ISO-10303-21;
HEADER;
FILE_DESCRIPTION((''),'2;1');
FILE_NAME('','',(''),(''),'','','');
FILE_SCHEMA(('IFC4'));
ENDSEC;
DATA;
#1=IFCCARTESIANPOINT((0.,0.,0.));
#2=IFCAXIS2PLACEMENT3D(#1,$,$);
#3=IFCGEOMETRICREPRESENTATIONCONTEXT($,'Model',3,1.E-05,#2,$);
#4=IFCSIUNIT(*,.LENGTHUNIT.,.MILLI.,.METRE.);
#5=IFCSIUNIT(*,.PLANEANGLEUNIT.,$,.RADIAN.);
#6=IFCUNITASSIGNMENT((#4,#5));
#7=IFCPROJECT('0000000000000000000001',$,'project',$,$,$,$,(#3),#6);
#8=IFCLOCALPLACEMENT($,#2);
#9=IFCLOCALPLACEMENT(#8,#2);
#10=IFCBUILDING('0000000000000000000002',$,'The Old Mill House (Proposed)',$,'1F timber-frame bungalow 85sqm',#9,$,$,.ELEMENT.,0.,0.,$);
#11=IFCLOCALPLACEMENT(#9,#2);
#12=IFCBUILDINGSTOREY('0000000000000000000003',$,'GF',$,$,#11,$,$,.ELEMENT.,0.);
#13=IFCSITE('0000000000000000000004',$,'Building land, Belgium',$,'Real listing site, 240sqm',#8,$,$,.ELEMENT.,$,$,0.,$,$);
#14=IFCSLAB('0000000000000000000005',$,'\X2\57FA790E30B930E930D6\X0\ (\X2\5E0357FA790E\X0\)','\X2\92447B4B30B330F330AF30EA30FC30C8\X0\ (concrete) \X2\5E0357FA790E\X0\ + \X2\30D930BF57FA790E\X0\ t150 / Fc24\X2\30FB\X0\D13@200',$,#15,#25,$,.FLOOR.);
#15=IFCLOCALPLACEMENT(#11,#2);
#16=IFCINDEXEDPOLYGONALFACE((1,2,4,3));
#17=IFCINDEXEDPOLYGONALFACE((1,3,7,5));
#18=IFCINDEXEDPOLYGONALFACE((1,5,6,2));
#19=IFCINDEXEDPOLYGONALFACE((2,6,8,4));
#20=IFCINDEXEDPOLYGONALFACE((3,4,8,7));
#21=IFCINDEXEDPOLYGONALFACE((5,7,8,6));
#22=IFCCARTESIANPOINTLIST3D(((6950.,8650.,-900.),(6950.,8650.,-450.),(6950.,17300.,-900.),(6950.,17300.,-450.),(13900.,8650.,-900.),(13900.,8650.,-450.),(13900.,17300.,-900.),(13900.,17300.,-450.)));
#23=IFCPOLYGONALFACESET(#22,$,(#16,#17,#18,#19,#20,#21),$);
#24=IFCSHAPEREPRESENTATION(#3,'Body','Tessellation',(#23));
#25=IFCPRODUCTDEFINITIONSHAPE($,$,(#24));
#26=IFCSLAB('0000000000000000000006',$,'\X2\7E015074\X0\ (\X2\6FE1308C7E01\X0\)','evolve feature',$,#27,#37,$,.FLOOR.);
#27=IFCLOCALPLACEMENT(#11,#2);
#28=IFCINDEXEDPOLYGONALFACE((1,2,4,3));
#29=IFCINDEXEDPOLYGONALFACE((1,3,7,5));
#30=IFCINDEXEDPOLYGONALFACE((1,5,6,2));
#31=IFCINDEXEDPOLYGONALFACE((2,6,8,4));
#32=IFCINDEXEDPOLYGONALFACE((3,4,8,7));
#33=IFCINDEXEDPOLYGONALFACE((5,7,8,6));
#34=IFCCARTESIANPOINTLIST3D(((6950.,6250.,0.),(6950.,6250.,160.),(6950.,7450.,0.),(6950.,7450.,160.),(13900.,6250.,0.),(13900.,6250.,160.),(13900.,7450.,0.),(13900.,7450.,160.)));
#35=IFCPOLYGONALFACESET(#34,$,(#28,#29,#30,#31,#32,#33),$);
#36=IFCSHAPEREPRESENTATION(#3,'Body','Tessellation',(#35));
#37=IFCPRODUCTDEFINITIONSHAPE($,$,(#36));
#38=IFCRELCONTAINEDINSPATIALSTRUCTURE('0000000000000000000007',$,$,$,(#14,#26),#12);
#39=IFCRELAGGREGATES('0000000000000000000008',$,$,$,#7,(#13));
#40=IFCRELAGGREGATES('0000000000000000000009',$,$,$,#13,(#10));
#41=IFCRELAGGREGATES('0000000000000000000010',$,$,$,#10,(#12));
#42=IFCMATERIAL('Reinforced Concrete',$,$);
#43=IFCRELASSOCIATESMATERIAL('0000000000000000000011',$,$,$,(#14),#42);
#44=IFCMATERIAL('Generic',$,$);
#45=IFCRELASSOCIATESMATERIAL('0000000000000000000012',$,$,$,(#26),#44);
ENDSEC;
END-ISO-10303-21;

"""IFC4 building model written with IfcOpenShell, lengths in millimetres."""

from ifc_helpers import new_model, si_unit, frame, frame_2d, origin, place, context, project, spatial, rectangle, extrude, material, element, save


model = new_model("IFC4")

# Units and contexts
model_context = context("Model", 3, precision=1e-05, world=origin())
ifc_project = project(units=[si_unit("LENGTHUNIT", "METRE", prefix="MILLI"), si_unit("PLANEANGLEUNIT", "RADIAN")], contexts=[model_context])

# Site, building, storey
site_placement = place(None, origin())
site = spatial("IfcSite", under=ifc_project, at=site_placement, Name="Building land, Belgium", ObjectType="Real listing site, 240sqm", CompositionType="ELEMENT", RefElevation=0.0)
building_placement = place(site_placement, origin())
building = spatial("IfcBuilding", under=site, at=building_placement, Name="The Old Mill House (Proposed)", ObjectType="1F timber-frame bungalow 85sqm", CompositionType="ELEMENT", ElevationOfRefHeight=0.0, ElevationOfTerrain=0.0)
storey_placement = place(building_placement, origin())
storey = spatial("IfcBuildingStorey", under=building, at=storey_placement, Name="GF", CompositionType="ELEMENT", Elevation=0.0)

# Slabs
ifc_material_1 = material(Name="Reinforced Concrete")
slab_1_placement = place(storey_placement, frame((3475.0, 4325.0, -450.0)))
element("IfcSlab", 1, at=slab_1_placement, inside=storey, material=ifc_material_1, Name="基礎スラブ (布基礎)", Description="鉄筋コンクリート (concrete) 布基礎 + ベタ基礎 t150 / Fc24・D13@200", PredefinedType="FLOOR", context=model_context, shape_type="SweptSolid", body=[
    extrude(rectangle(XDim=6950.0, YDim=8650.0, at=frame_2d((3475.0, 4325.0))), frame((3475.0, 4325.0, -450.0)), (0.0, 0.0, 1.0), 450.0),
])
ifc_material_2 = material(Name="Generic")
slab_2_placement = place(storey_placement, frame((3475.0, 3125.0, 0.0)))
element("IfcSlab", 2, at=slab_2_placement, inside=storey, material=ifc_material_2, Name="縁側 (濡れ縁)", Description="evolve feature", PredefinedType="FLOOR", context=model_context, shape_type="SweptSolid", body=[
    extrude(rectangle(XDim=6950.0, YDim=1200.0, at=frame_2d((3475.0, 600.0))), frame((3475.0, 3125.0, 0.0)), (0.0, 0.0, 1.0), 160.0),
])

save(model, "model.ifc")
